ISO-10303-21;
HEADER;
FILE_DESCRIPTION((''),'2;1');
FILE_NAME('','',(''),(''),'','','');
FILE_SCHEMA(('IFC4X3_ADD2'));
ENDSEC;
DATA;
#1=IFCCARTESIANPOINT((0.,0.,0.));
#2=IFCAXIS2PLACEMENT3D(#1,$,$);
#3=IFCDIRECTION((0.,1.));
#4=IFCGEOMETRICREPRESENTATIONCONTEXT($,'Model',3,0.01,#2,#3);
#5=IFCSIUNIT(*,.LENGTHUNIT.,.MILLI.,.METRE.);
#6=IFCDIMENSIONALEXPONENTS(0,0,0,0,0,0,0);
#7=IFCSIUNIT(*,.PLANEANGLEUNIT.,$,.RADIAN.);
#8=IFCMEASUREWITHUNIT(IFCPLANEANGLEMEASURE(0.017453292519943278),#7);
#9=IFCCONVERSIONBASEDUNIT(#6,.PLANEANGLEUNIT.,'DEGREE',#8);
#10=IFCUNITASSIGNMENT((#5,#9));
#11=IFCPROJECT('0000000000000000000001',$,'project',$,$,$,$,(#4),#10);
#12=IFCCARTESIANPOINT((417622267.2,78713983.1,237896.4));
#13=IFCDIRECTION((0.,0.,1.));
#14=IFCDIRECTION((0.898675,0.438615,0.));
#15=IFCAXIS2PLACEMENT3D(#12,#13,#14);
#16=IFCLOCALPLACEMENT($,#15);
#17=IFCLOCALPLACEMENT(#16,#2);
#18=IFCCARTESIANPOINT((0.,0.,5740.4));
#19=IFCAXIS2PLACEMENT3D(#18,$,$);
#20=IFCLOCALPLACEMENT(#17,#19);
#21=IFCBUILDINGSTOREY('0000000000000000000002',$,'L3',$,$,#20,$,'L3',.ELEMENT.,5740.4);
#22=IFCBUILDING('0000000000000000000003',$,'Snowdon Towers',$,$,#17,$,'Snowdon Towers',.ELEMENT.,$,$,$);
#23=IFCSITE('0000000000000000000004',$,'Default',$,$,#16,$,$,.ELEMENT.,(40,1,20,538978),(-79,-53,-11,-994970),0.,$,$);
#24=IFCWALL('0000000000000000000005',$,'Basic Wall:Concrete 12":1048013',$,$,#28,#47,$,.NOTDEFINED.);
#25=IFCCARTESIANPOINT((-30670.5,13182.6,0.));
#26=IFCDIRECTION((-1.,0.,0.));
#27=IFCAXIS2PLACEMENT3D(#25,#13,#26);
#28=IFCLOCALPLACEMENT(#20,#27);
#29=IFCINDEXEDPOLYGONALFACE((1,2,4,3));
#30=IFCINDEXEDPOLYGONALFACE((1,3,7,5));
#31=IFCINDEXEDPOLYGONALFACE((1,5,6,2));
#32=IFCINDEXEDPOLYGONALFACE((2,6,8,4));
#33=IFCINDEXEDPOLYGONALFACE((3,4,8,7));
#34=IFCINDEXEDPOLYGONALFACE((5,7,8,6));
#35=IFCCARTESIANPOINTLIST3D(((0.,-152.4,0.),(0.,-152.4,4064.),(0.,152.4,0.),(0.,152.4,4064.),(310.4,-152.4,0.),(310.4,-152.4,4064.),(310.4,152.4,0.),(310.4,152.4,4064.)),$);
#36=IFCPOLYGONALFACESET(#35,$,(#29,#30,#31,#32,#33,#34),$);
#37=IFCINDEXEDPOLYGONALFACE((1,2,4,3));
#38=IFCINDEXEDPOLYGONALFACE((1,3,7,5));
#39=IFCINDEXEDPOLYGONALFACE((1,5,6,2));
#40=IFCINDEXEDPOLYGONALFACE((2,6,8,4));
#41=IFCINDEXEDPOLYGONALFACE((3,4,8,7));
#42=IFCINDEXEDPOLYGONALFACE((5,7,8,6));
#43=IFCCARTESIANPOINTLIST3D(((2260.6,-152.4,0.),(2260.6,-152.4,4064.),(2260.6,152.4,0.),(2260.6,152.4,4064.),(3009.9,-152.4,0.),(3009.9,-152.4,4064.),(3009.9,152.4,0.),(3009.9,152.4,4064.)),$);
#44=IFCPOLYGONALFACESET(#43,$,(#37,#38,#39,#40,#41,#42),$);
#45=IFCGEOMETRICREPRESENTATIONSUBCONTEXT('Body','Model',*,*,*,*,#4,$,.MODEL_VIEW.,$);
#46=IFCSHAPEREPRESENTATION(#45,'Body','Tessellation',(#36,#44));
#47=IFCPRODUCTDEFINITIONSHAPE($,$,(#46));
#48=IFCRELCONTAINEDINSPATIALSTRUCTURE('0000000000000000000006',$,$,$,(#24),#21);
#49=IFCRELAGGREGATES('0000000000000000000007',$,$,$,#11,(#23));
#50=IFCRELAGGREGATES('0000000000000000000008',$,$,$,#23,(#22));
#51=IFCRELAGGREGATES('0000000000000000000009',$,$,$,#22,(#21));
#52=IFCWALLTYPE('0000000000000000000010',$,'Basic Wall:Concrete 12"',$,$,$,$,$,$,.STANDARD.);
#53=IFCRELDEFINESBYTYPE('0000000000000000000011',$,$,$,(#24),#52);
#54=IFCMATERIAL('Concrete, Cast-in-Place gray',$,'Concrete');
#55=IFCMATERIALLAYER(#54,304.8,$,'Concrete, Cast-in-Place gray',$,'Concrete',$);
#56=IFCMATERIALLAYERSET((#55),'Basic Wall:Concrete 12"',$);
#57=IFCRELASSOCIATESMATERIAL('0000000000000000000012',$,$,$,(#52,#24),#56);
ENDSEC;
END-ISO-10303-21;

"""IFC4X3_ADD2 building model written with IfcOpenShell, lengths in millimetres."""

from ifc_helpers import new_model, entity, si_unit, converted_unit, direction, frame, frame_2d, origin, place, context, subcontext, project, spatial, rectangle, extrude, material, layer, layer_set, type_object, element, save


model = new_model("IFC4X3_ADD2")

# Units and contexts
model_context = context("Model", 3, precision=0.01, world=origin(), true_north=direction((0.0, 1.0)))
body_context = subcontext(model_context, "Body", "Model", "MODEL_VIEW")
ifc_project = project(units=[si_unit("LENGTHUNIT", "METRE", prefix="MILLI"), converted_unit("PLANEANGLEUNIT", "DEGREE", entity("IfcPlaneAngleMeasure", 0.017453292519943278), si_unit("PLANEANGLEUNIT", "RADIAN"), dimensions=[0, 0, 0, 0, 0, 0, 0])], contexts=[model_context])

# Site, building, storey
site_placement = place(None, frame((417622267.2, 78713983.1, 237896.4), z_axis=(0.0, 0.0, 1.0), x_axis=(0.898675, 0.438615, 0.0)))
site = spatial("IfcSite", under=ifc_project, at=site_placement, Name="Default", CompositionType="ELEMENT", RefLatitude=(40, 1, 20, 538978), RefLongitude=(-79, -53, -11, -994970), RefElevation=0.0)
building_placement = place(site_placement, origin())
building = spatial("IfcBuilding", under=site, at=building_placement, Name="Snowdon Towers", LongName="Snowdon Towers", CompositionType="ELEMENT")
storey_placement = place(building_placement, frame((0.0, 0.0, 5740.4)))
storey = spatial("IfcBuildingStorey", under=building, at=storey_placement, Name="L3", LongName="L3", CompositionType="ELEMENT", Elevation=5740.4)

# Shared definitions
ifc_material_1 = material(Name="Concrete, Cast-in-Place gray", Category="Concrete")

# Wall
ifc_layer_1 = layer(ifc_material_1, 304.8, Name="Concrete, Cast-in-Place gray", Category="Concrete")
ifc_layer_set_1 = layer_set([ifc_layer_1], Name="Basic Wall:Concrete 12\"")
wall_type_1 = type_object("IfcWallType", Name="Basic Wall:Concrete 12\"", PredefinedType="STANDARD", material=ifc_layer_set_1)
wall_1_placement = place(storey_placement, frame((-30670.5, 13182.6, 0.0), z_axis=(0.0, 0.0, 1.0), x_axis=(-1.0, 0.0, 0.0)))
element("IfcWall", 1, at=wall_1_placement, inside=storey, type_object=wall_type_1, material=ifc_layer_set_1, Name="Basic Wall:Concrete 12\":1048013", PredefinedType="NOTDEFINED", context=body_context, shape_type="SweptSolid", body=[
    extrude(rectangle(XDim=304.8, YDim=310.4, at=frame_2d((0.0, 41.4), x_axis=(1.0, 0.0))), frame((196.6, 0.0, 0.0), z_axis=(0.0, 0.0, 1.0), x_axis=(0.0, 1.0, 0.0)), (0.0, 0.0, 1.0), 4064.0),
    extrude(rectangle(XDim=304.8, YDim=749.3, at=frame_2d((0.0, 0.0), x_axis=(1.0, 0.0))), frame((2635.3, 0.0, 0.0), z_axis=(0.0, 0.0, 1.0), x_axis=(0.0, 1.0, 0.0)), (0.0, 0.0, 1.0), 4064.0),
])

save(model, "model.ifc")
